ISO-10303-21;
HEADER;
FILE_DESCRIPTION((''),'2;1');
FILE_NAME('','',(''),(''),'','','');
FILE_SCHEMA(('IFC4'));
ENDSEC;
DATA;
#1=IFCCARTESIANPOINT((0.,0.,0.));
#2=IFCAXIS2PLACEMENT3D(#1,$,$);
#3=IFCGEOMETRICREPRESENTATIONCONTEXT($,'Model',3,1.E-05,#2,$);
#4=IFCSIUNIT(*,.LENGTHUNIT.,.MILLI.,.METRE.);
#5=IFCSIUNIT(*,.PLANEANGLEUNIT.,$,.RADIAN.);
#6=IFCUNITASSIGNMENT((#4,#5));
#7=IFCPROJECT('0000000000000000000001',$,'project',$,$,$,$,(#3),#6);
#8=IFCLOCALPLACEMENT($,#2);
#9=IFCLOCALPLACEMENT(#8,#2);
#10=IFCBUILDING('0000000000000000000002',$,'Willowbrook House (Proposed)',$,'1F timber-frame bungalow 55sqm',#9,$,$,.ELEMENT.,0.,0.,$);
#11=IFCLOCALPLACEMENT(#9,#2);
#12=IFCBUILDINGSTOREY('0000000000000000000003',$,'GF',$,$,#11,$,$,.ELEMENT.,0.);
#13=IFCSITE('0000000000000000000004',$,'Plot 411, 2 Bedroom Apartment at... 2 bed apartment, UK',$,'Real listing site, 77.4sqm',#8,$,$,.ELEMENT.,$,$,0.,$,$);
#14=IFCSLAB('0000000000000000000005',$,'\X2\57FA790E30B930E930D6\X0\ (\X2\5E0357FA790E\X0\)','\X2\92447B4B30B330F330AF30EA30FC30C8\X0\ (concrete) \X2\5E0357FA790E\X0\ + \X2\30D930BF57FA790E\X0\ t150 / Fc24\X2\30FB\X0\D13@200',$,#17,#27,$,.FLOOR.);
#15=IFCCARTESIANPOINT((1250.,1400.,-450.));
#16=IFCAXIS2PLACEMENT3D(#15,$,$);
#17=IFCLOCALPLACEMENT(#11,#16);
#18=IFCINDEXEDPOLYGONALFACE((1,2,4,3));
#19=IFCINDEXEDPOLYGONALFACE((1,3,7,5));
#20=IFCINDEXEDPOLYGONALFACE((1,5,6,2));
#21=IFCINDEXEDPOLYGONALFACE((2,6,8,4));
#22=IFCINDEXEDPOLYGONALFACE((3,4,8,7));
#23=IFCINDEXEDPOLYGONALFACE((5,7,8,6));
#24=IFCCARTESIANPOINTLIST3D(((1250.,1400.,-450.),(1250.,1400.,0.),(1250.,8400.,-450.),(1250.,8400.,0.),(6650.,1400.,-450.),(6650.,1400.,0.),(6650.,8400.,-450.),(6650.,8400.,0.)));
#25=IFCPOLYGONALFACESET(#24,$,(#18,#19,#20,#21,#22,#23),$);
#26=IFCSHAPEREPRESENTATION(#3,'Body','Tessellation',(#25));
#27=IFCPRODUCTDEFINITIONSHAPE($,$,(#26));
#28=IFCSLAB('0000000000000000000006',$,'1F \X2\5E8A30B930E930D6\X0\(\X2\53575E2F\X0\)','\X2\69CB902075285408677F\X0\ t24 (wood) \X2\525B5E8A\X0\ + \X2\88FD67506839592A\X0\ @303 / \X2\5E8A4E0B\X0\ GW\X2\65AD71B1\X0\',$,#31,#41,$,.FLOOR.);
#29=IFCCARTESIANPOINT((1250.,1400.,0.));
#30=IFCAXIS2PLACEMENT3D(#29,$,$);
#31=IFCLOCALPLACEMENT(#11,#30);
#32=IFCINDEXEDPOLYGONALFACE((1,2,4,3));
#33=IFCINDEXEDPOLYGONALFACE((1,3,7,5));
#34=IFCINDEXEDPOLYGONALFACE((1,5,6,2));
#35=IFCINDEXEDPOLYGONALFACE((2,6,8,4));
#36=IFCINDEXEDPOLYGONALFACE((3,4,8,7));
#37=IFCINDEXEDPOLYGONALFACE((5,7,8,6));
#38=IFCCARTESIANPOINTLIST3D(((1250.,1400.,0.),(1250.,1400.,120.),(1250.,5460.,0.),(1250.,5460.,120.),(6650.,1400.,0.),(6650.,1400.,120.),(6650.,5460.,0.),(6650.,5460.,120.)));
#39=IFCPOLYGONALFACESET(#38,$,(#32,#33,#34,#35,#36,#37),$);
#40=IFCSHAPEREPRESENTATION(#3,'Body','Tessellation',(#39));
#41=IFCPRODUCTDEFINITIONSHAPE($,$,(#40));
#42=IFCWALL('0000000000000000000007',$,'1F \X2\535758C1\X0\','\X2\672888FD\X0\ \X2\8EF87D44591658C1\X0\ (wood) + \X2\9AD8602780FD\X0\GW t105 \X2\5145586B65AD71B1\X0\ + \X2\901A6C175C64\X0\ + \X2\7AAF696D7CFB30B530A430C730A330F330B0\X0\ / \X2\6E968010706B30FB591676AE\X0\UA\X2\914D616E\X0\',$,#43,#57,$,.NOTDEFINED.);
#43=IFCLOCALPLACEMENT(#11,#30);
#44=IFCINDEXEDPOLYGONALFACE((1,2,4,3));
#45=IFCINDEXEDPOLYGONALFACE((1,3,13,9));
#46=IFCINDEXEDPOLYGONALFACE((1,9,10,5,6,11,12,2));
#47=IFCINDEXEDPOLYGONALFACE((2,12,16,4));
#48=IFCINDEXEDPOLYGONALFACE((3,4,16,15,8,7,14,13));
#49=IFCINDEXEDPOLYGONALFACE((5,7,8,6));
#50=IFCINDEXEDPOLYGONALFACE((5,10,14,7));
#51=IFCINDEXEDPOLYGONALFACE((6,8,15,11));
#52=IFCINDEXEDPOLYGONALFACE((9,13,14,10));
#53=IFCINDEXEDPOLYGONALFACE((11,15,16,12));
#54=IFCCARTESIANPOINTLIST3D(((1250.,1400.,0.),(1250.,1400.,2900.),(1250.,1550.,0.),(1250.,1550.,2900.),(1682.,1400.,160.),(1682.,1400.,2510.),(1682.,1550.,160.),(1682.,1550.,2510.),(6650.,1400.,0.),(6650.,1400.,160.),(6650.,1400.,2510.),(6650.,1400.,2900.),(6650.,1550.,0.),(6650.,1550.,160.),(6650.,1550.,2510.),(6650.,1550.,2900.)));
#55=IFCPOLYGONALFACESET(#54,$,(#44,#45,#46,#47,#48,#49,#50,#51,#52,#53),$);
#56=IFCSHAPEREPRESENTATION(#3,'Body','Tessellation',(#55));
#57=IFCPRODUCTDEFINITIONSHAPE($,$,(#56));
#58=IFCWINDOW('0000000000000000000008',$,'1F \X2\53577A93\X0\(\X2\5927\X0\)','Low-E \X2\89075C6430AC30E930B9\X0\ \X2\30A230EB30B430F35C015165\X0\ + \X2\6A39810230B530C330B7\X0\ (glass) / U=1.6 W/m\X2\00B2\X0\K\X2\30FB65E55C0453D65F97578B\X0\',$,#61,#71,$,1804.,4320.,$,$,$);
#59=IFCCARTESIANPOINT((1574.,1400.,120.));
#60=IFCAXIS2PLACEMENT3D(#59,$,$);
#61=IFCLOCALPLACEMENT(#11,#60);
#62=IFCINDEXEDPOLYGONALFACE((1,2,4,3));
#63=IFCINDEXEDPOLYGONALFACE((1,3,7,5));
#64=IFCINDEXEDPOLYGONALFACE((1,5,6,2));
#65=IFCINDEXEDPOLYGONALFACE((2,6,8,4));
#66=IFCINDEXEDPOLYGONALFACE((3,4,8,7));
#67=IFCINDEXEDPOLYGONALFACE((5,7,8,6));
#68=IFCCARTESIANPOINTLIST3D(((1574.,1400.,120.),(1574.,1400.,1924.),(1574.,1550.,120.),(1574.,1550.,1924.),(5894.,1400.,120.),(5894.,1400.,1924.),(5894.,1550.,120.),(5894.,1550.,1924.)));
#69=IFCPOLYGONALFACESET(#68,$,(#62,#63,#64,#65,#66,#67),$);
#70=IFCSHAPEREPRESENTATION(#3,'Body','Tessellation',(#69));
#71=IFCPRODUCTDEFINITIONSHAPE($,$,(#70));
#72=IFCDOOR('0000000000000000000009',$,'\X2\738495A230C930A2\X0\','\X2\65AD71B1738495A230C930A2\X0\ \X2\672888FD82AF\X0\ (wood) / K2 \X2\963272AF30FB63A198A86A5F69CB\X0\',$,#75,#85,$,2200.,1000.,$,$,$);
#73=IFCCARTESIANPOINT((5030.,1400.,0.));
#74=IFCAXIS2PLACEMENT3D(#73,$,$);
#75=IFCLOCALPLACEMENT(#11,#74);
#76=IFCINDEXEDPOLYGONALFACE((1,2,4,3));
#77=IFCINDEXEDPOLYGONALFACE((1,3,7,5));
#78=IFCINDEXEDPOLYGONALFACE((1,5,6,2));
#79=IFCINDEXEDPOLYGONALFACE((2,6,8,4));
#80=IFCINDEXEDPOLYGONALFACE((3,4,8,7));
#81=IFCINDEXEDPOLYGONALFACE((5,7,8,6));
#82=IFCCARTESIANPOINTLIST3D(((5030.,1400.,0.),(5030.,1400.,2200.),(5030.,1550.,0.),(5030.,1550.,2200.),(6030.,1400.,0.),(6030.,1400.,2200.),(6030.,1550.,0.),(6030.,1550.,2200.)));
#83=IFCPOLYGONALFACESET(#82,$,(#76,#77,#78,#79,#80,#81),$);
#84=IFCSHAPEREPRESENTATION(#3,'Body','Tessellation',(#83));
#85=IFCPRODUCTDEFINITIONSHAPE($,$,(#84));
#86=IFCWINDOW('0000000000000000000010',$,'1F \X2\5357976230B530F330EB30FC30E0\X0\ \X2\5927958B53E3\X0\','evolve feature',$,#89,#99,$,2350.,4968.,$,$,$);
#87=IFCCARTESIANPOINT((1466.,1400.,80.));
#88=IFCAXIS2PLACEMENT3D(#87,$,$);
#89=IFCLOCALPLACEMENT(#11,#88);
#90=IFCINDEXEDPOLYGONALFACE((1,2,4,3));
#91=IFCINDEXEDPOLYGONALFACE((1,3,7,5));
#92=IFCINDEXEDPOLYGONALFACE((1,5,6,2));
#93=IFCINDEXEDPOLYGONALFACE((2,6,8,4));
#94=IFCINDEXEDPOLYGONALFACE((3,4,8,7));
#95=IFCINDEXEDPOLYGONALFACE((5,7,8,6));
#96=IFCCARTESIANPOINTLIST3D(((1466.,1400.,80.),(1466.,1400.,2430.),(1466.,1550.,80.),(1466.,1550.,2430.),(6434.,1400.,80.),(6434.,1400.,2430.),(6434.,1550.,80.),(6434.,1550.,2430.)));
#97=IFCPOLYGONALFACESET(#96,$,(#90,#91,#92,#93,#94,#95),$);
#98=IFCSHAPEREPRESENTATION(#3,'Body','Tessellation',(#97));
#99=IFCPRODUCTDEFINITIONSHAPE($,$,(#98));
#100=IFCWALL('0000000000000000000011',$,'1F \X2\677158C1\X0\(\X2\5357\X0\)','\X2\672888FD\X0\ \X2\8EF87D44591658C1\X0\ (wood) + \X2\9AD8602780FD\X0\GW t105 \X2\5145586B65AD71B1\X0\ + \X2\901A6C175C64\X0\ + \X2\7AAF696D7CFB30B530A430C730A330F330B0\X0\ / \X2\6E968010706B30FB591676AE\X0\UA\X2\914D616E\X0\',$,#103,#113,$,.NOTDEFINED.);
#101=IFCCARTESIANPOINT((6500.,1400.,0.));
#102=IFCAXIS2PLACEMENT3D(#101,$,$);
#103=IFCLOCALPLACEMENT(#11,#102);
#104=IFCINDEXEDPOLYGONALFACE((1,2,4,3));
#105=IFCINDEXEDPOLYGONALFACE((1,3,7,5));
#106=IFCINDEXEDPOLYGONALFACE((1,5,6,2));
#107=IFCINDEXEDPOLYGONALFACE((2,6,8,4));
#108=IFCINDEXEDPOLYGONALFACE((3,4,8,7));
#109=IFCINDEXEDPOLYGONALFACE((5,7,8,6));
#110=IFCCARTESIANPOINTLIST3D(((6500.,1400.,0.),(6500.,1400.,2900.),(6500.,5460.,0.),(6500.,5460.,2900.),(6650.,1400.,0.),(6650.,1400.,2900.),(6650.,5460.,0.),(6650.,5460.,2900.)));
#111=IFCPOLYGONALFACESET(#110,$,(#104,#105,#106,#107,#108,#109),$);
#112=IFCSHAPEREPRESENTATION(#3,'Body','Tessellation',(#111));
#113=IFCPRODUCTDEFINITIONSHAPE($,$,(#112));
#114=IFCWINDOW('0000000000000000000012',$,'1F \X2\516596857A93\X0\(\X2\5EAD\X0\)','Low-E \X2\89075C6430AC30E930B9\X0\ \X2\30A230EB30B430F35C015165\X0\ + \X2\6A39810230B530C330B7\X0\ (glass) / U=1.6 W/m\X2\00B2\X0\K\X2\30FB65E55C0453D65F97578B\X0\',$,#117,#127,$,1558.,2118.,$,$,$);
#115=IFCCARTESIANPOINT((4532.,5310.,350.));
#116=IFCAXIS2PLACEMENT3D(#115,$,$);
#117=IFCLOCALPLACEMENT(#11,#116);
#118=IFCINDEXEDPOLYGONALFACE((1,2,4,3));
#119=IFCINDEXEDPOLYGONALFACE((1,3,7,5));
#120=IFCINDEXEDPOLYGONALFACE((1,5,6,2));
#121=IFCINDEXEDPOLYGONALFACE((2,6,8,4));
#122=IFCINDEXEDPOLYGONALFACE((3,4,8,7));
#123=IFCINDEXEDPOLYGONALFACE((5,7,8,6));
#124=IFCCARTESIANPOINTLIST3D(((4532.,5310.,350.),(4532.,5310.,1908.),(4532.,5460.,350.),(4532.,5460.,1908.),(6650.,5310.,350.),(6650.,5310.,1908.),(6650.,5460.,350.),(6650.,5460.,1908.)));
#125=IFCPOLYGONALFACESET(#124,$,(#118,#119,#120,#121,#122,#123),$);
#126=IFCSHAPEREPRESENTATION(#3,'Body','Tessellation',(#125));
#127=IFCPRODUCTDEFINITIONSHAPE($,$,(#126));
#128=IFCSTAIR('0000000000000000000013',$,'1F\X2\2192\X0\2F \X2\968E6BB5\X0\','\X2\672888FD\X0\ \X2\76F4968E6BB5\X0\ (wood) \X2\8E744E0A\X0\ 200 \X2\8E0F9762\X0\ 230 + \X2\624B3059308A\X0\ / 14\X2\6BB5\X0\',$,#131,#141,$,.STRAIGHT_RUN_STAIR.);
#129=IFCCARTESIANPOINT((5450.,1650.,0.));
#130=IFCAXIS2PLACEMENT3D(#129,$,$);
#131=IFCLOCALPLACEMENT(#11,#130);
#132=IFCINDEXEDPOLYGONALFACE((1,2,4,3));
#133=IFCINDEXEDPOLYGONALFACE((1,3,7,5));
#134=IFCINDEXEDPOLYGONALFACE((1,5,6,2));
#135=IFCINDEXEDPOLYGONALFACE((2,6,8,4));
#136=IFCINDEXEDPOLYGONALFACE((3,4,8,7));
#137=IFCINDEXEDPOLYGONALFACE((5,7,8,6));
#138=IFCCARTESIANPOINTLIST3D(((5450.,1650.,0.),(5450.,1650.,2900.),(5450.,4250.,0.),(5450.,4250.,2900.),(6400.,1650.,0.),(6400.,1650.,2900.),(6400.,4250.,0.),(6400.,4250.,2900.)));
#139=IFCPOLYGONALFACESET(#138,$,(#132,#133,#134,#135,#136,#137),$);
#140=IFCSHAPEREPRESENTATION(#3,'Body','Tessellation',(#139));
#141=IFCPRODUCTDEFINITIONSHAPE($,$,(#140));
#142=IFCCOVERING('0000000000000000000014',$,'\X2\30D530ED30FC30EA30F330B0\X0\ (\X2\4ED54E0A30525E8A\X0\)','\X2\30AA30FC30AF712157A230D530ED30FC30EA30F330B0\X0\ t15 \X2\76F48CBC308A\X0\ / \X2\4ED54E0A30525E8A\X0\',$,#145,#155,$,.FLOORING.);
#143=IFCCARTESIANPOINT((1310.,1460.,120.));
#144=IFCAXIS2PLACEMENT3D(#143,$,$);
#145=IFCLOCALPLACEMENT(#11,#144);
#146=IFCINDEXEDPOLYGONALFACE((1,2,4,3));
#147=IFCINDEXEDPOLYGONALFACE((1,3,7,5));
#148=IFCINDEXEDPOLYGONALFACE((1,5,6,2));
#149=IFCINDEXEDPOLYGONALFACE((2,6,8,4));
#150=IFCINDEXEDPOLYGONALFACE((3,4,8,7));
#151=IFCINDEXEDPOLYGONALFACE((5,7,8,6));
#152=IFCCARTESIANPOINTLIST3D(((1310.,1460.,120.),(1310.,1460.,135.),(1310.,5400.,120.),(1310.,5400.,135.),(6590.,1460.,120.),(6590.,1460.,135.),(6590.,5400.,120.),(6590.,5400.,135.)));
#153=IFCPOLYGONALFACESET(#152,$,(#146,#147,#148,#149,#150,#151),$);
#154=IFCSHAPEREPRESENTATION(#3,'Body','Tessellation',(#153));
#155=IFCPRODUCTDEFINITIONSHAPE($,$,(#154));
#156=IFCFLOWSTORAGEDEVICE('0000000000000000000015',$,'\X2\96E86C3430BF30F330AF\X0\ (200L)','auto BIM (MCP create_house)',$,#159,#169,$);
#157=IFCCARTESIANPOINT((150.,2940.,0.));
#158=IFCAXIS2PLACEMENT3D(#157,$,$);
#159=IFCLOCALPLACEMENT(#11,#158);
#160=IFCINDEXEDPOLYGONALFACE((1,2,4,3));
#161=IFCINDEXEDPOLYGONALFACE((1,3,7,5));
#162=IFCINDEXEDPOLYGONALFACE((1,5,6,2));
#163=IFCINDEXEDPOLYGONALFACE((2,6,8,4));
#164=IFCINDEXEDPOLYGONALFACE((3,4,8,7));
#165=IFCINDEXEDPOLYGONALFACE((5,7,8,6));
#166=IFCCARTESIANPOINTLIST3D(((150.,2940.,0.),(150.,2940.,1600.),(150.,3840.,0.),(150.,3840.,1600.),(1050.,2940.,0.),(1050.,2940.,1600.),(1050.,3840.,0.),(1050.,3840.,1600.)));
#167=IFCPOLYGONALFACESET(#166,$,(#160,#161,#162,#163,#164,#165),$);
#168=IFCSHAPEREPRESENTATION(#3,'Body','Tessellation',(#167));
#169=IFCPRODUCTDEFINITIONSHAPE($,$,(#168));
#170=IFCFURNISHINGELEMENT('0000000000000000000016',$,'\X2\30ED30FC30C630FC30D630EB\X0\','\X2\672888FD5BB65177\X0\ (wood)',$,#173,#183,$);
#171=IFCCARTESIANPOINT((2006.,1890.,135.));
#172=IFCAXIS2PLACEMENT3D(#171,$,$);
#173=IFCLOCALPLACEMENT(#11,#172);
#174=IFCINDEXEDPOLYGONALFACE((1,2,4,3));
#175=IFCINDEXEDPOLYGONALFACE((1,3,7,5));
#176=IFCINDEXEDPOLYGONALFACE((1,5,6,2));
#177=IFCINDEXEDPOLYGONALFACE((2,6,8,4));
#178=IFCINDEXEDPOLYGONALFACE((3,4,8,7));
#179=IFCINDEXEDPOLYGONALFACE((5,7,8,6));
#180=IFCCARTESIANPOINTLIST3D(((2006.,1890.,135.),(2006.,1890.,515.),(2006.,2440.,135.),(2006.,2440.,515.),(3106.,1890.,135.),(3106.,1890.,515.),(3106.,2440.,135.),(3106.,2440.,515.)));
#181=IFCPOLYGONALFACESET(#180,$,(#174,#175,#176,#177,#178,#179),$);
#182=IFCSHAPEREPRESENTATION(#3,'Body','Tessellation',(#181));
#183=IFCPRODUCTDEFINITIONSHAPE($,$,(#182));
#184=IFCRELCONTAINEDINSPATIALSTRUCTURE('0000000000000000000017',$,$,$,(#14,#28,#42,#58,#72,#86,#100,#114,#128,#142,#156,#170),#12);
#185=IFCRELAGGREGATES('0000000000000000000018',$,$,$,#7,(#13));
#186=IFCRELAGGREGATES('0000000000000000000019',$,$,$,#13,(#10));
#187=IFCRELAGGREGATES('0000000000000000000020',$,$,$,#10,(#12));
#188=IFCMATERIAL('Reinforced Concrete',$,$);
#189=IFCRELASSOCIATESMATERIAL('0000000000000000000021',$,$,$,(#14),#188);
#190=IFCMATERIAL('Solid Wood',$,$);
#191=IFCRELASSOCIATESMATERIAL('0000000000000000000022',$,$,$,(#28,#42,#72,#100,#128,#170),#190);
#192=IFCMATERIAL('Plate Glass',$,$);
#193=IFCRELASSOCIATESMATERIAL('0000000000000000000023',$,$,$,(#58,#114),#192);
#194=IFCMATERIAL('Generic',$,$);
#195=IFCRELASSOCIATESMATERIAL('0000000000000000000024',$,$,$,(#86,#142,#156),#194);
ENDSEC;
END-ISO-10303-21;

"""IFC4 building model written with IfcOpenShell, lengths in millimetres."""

from ifc_helpers import new_model, si_unit, frame, frame_2d, origin, place, context, project, spatial, rectangle, extrude, material, element, fill, save


model = new_model("IFC4")

# Units and contexts
model_context = context("Model", 3, precision=1e-05, world=origin())
ifc_project = project(units=[si_unit("LENGTHUNIT", "METRE", prefix="MILLI"), si_unit("PLANEANGLEUNIT", "RADIAN")], contexts=[model_context])

# Site, building, storey
site_placement = place(None, origin())
site = spatial("IfcSite", under=ifc_project, at=site_placement, Name="Plot 411, 2 Bedroom Apartment at... 2 bed apartment, UK", ObjectType="Real listing site, 77.4sqm", CompositionType="ELEMENT", RefElevation=0.0)
building_placement = place(site_placement, origin())
building = spatial("IfcBuilding", under=site, at=building_placement, Name="Willowbrook House (Proposed)", ObjectType="1F timber-frame bungalow 55sqm", CompositionType="ELEMENT", ElevationOfRefHeight=0.0, ElevationOfTerrain=0.0)
storey_placement = place(building_placement, origin())
storey = spatial("IfcBuildingStorey", under=building, at=storey_placement, Name="GF", CompositionType="ELEMENT", Elevation=0.0)

# Slabs
ifc_material_1 = material(Name="Reinforced Concrete")
slab_1_placement = place(storey_placement, frame((1250.0, 1400.0, -450.0)))
element("IfcSlab", 1, at=slab_1_placement, inside=storey, material=ifc_material_1, Name="基礎スラブ (布基礎)", Description="鉄筋コンクリート (concrete) 布基礎 + ベタ基礎 t150 / Fc24・D13@200", PredefinedType="FLOOR", context=model_context, shape_type="SweptSolid", body=[
    extrude(rectangle(XDim=5400.0, YDim=7000.0, at=frame_2d((2700.0, 3500.0))), frame((1250.0, 1400.0, -450.0)), (0.0, 0.0, 1.0), 450.0),
])
ifc_material_2 = material(Name="Solid Wood")
slab_2_placement = place(storey_placement, frame((1250.0, 1400.0, 0.0)))
element("IfcSlab", 2, at=slab_2_placement, inside=storey, material=ifc_material_2, Name="1F 床スラブ(南帯)", Description="構造用合板 t24 (wood) 剛床 + 製材根太 @303 / 床下 GW断熱", PredefinedType="FLOOR", context=model_context, shape_type="SweptSolid", body=[
    extrude(rectangle(XDim=5400.0, YDim=4060.0, at=frame_2d((2700.0, 2030.0))), frame((1250.0, 1400.0, 0.0)), (0.0, 0.0, 1.0), 120.0),
])

# Wall, openings, windows, door
wall_1_placement = place(storey_placement, frame((1250.0, 1400.0, 0.0)))
wall_1 = element("IfcWall", 3, at=wall_1_placement, inside=storey, material=ifc_material_2, Name="1F 南壁", Description="木製 軸組外壁 (wood) + 高性能GW t105 充填断熱 + 通気層 + 窯業系サイディング / 準耐火・外皮UA配慮", PredefinedType="NOTDEFINED", context=model_context, shape_type="SweptSolid", body=[
    extrude(rectangle(XDim=5400.0, YDim=150.0, at=frame_2d((2700.0, 75.0))), frame((1250.0, 1400.0, 0.0)), (0.0, 0.0, 1.0), 2900.0),
])
opening_1_placement = place(storey_placement, frame((1574.0, 1400.0, 120.0)))
opening_1 = element("IfcOpeningElement", 4, at=opening_1_placement, cuts=wall_1, PredefinedType="NOTDEFINED", context=model_context, shape_type="SweptSolid", body=[
    extrude(rectangle(XDim=4320.0, YDim=150.0, at=frame_2d((2160.0, 75.0))), frame((1574.0, 1400.0, 120.0)), (0.0, 0.0, 1.0), 1804.0),
])
opening_2_placement = place(storey_placement, frame((5030.0, 1400.0, 0.0)))
opening_2 = element("IfcOpeningElement", 5, at=opening_2_placement, cuts=wall_1, PredefinedType="NOTDEFINED", context=model_context, shape_type="SweptSolid", body=[
    extrude(rectangle(XDim=1000.0, YDim=150.0, at=frame_2d((500.0, 75.0))), frame((5030.0, 1400.0, 0.0)), (0.0, 0.0, 1.0), 2200.0),
])
opening_3_placement = place(storey_placement, frame((1466.0, 1400.0, 80.0)))
opening_3 = element("IfcOpeningElement", 6, at=opening_3_placement, cuts=wall_1, PredefinedType="NOTDEFINED", context=model_context, shape_type="SweptSolid", body=[
    extrude(rectangle(XDim=4968.0, YDim=150.0, at=frame_2d((2484.0, 75.0))), frame((1466.0, 1400.0, 80.0)), (0.0, 0.0, 1.0), 2350.0),
])
ifc_material_3 = material(Name="Plate Glass")
window_1_placement = place(storey_placement, frame((1574.0, 1400.0, 120.0)))
window_1 = element("IfcWindow", 7, at=window_1_placement, inside=storey, material=ifc_material_3, Name="1F 南窓(大)", Description="Low-E 複層ガラス アルゴン封入 + 樹脂サッシ (glass) / U=1.6 W/m²K・日射取得型", OverallHeight=1804.0, OverallWidth=4320.0, context=model_context, shape_type="SweptSolid", body=[
    extrude(rectangle(XDim=4320.0, YDim=150.0, at=frame_2d((2160.0, 75.0))), frame((1574.0, 1400.0, 120.0)), (0.0, 0.0, 1.0), 1804.0),
])
fill(opening_1, window_1)
door_1_placement = place(storey_placement, frame((5030.0, 1400.0, 0.0)))
door_1 = element("IfcDoor", 8, at=door_1_placement, inside=storey, material=ifc_material_2, Name="玄関ドア", Description="断熱玄関ドア 木製芯 (wood) / K2 防犯・採風機構", OverallHeight=2200.0, OverallWidth=1000.0, context=model_context, shape_type="SweptSolid", body=[
    extrude(rectangle(XDim=1000.0, YDim=150.0, at=frame_2d((500.0, 75.0))), frame((5030.0, 1400.0, 0.0)), (0.0, 0.0, 1.0), 2200.0),
])
fill(opening_2, door_1)
ifc_material_4 = material(Name="Generic")
window_2_placement = place(storey_placement, frame((1466.0, 1400.0, 80.0)))
window_2 = element("IfcWindow", 9, at=window_2_placement, inside=storey, material=ifc_material_4, Name="1F 南面サンルーム 大開口", Description="evolve feature", OverallHeight=2350.0, OverallWidth=4968.0, context=model_context, shape_type="SweptSolid", body=[
    extrude(rectangle(XDim=4968.0, YDim=150.0, at=frame_2d((2484.0, 75.0))), frame((1466.0, 1400.0, 80.0)), (0.0, 0.0, 1.0), 2350.0),
])
fill(opening_3, window_2)

# Wall, opening, window
wall_2_placement = place(storey_placement, frame((6500.0, 1400.0, 0.0)))
wall_2 = element("IfcWall", 10, at=wall_2_placement, inside=storey, material=ifc_material_2, Name="1F 東壁(南)", Description="木製 軸組外壁 (wood) + 高性能GW t105 充填断熱 + 通気層 + 窯業系サイディング / 準耐火・外皮UA配慮", PredefinedType="NOTDEFINED", context=model_context, shape_type="SweptSolid", body=[
    extrude(rectangle(XDim=150.0, YDim=4060.0, at=frame_2d((75.0, 2030.0))), frame((6500.0, 1400.0, 0.0)), (0.0, 0.0, 1.0), 2900.0),
])
opening_4_placement = place(storey_placement, frame((4532.0, 5310.0, 350.0)))
opening_4 = element("IfcOpeningElement", 11, at=opening_4_placement, cuts=wall_2, PredefinedType="NOTDEFINED", context=model_context, shape_type="SweptSolid", body=[
    extrude(rectangle(XDim=2118.0, YDim=150.0, at=frame_2d((1059.0, 75.0))), frame((4532.0, 5310.0, 350.0)), (0.0, 0.0, 1.0), 1558.0),
])
window_3_placement = place(storey_placement, frame((4532.0, 5310.0, 350.0)))
window_3 = element("IfcWindow", 12, at=window_3_placement, inside=storey, material=ifc_material_3, Name="1F 入隅窓(庭)", Description="Low-E 複層ガラス アルゴン封入 + 樹脂サッシ (glass) / U=1.6 W/m²K・日射取得型", OverallHeight=1558.0, OverallWidth=2118.0, context=model_context, shape_type="SweptSolid", body=[
    extrude(rectangle(XDim=2118.0, YDim=150.0, at=frame_2d((1059.0, 75.0))), frame((4532.0, 5310.0, 350.0)), (0.0, 0.0, 1.0), 1558.0),
])
fill(opening_4, window_3)

# Stair
stair_placement = place(storey_placement, frame((5450.0, 1650.0, 0.0)))
element("IfcStair", 13, at=stair_placement, inside=storey, material=ifc_material_2, Name="1F→2F 階段", Description="木製 直階段 (wood) 蹴上 200 踏面 230 + 手すり / 14段", PredefinedType="STRAIGHT_RUN_STAIR", context=model_context, shape_type="SweptSolid", body=[
    extrude(rectangle(XDim=950.0, YDim=2600.0, at=frame_2d((475.0, 1300.0))), frame((5450.0, 1650.0, 0.0)), (0.0, 0.0, 1.0), 2900.0),
])

# Covering
covering_placement = place(storey_placement, frame((1310.0, 1460.0, 120.0)))
element("IfcCovering", 14, at=covering_placement, inside=storey, material=ifc_material_4, Name="フローリング (仕上げ床)", Description="オーク無垢フローリング t15 直貼り / 仕上げ床", PredefinedType="FLOORING", context=model_context, shape_type="SweptSolid", body=[
    extrude(rectangle(XDim=5280.0, YDim=3940.0, at=frame_2d((2640.0, 1970.0))), frame((1310.0, 1460.0, 120.0)), (0.0, 0.0, 1.0), 15.0),
])

# Flow storage device
flow_storage_device_placement = place(storey_placement, frame((150.0, 2940.0, 0.0)))
element("IfcFlowStorageDevice", 15, at=flow_storage_device_placement, inside=storey, material=ifc_material_4, Name="雨水タンク (200L)", Description="auto BIM (MCP create_house)", context=model_context, shape_type="SweptSolid", body=[
    extrude(rectangle(XDim=900.0, YDim=900.0, at=frame_2d((450.0, 450.0))), frame((150.0, 2940.0, 0.0)), (0.0, 0.0, 1.0), 1600.0),
])

# Furnishing element
furnishing_1_placement = place(storey_placement, frame((2006.0, 1890.0, 135.0)))
element("IfcFurnishingElement", 16, at=furnishing_1_placement, inside=storey, material=ifc_material_2, Name="ローテーブル", Description="木製家具 (wood)", context=model_context, shape_type="SweptSolid", body=[
    extrude(rectangle(XDim=1100.0, YDim=550.0, at=frame_2d((550.0, 275.0))), frame((2006.0, 1890.0, 135.0)), (0.0, 0.0, 1.0), 380.0),
])

save(model, "model.ifc")
